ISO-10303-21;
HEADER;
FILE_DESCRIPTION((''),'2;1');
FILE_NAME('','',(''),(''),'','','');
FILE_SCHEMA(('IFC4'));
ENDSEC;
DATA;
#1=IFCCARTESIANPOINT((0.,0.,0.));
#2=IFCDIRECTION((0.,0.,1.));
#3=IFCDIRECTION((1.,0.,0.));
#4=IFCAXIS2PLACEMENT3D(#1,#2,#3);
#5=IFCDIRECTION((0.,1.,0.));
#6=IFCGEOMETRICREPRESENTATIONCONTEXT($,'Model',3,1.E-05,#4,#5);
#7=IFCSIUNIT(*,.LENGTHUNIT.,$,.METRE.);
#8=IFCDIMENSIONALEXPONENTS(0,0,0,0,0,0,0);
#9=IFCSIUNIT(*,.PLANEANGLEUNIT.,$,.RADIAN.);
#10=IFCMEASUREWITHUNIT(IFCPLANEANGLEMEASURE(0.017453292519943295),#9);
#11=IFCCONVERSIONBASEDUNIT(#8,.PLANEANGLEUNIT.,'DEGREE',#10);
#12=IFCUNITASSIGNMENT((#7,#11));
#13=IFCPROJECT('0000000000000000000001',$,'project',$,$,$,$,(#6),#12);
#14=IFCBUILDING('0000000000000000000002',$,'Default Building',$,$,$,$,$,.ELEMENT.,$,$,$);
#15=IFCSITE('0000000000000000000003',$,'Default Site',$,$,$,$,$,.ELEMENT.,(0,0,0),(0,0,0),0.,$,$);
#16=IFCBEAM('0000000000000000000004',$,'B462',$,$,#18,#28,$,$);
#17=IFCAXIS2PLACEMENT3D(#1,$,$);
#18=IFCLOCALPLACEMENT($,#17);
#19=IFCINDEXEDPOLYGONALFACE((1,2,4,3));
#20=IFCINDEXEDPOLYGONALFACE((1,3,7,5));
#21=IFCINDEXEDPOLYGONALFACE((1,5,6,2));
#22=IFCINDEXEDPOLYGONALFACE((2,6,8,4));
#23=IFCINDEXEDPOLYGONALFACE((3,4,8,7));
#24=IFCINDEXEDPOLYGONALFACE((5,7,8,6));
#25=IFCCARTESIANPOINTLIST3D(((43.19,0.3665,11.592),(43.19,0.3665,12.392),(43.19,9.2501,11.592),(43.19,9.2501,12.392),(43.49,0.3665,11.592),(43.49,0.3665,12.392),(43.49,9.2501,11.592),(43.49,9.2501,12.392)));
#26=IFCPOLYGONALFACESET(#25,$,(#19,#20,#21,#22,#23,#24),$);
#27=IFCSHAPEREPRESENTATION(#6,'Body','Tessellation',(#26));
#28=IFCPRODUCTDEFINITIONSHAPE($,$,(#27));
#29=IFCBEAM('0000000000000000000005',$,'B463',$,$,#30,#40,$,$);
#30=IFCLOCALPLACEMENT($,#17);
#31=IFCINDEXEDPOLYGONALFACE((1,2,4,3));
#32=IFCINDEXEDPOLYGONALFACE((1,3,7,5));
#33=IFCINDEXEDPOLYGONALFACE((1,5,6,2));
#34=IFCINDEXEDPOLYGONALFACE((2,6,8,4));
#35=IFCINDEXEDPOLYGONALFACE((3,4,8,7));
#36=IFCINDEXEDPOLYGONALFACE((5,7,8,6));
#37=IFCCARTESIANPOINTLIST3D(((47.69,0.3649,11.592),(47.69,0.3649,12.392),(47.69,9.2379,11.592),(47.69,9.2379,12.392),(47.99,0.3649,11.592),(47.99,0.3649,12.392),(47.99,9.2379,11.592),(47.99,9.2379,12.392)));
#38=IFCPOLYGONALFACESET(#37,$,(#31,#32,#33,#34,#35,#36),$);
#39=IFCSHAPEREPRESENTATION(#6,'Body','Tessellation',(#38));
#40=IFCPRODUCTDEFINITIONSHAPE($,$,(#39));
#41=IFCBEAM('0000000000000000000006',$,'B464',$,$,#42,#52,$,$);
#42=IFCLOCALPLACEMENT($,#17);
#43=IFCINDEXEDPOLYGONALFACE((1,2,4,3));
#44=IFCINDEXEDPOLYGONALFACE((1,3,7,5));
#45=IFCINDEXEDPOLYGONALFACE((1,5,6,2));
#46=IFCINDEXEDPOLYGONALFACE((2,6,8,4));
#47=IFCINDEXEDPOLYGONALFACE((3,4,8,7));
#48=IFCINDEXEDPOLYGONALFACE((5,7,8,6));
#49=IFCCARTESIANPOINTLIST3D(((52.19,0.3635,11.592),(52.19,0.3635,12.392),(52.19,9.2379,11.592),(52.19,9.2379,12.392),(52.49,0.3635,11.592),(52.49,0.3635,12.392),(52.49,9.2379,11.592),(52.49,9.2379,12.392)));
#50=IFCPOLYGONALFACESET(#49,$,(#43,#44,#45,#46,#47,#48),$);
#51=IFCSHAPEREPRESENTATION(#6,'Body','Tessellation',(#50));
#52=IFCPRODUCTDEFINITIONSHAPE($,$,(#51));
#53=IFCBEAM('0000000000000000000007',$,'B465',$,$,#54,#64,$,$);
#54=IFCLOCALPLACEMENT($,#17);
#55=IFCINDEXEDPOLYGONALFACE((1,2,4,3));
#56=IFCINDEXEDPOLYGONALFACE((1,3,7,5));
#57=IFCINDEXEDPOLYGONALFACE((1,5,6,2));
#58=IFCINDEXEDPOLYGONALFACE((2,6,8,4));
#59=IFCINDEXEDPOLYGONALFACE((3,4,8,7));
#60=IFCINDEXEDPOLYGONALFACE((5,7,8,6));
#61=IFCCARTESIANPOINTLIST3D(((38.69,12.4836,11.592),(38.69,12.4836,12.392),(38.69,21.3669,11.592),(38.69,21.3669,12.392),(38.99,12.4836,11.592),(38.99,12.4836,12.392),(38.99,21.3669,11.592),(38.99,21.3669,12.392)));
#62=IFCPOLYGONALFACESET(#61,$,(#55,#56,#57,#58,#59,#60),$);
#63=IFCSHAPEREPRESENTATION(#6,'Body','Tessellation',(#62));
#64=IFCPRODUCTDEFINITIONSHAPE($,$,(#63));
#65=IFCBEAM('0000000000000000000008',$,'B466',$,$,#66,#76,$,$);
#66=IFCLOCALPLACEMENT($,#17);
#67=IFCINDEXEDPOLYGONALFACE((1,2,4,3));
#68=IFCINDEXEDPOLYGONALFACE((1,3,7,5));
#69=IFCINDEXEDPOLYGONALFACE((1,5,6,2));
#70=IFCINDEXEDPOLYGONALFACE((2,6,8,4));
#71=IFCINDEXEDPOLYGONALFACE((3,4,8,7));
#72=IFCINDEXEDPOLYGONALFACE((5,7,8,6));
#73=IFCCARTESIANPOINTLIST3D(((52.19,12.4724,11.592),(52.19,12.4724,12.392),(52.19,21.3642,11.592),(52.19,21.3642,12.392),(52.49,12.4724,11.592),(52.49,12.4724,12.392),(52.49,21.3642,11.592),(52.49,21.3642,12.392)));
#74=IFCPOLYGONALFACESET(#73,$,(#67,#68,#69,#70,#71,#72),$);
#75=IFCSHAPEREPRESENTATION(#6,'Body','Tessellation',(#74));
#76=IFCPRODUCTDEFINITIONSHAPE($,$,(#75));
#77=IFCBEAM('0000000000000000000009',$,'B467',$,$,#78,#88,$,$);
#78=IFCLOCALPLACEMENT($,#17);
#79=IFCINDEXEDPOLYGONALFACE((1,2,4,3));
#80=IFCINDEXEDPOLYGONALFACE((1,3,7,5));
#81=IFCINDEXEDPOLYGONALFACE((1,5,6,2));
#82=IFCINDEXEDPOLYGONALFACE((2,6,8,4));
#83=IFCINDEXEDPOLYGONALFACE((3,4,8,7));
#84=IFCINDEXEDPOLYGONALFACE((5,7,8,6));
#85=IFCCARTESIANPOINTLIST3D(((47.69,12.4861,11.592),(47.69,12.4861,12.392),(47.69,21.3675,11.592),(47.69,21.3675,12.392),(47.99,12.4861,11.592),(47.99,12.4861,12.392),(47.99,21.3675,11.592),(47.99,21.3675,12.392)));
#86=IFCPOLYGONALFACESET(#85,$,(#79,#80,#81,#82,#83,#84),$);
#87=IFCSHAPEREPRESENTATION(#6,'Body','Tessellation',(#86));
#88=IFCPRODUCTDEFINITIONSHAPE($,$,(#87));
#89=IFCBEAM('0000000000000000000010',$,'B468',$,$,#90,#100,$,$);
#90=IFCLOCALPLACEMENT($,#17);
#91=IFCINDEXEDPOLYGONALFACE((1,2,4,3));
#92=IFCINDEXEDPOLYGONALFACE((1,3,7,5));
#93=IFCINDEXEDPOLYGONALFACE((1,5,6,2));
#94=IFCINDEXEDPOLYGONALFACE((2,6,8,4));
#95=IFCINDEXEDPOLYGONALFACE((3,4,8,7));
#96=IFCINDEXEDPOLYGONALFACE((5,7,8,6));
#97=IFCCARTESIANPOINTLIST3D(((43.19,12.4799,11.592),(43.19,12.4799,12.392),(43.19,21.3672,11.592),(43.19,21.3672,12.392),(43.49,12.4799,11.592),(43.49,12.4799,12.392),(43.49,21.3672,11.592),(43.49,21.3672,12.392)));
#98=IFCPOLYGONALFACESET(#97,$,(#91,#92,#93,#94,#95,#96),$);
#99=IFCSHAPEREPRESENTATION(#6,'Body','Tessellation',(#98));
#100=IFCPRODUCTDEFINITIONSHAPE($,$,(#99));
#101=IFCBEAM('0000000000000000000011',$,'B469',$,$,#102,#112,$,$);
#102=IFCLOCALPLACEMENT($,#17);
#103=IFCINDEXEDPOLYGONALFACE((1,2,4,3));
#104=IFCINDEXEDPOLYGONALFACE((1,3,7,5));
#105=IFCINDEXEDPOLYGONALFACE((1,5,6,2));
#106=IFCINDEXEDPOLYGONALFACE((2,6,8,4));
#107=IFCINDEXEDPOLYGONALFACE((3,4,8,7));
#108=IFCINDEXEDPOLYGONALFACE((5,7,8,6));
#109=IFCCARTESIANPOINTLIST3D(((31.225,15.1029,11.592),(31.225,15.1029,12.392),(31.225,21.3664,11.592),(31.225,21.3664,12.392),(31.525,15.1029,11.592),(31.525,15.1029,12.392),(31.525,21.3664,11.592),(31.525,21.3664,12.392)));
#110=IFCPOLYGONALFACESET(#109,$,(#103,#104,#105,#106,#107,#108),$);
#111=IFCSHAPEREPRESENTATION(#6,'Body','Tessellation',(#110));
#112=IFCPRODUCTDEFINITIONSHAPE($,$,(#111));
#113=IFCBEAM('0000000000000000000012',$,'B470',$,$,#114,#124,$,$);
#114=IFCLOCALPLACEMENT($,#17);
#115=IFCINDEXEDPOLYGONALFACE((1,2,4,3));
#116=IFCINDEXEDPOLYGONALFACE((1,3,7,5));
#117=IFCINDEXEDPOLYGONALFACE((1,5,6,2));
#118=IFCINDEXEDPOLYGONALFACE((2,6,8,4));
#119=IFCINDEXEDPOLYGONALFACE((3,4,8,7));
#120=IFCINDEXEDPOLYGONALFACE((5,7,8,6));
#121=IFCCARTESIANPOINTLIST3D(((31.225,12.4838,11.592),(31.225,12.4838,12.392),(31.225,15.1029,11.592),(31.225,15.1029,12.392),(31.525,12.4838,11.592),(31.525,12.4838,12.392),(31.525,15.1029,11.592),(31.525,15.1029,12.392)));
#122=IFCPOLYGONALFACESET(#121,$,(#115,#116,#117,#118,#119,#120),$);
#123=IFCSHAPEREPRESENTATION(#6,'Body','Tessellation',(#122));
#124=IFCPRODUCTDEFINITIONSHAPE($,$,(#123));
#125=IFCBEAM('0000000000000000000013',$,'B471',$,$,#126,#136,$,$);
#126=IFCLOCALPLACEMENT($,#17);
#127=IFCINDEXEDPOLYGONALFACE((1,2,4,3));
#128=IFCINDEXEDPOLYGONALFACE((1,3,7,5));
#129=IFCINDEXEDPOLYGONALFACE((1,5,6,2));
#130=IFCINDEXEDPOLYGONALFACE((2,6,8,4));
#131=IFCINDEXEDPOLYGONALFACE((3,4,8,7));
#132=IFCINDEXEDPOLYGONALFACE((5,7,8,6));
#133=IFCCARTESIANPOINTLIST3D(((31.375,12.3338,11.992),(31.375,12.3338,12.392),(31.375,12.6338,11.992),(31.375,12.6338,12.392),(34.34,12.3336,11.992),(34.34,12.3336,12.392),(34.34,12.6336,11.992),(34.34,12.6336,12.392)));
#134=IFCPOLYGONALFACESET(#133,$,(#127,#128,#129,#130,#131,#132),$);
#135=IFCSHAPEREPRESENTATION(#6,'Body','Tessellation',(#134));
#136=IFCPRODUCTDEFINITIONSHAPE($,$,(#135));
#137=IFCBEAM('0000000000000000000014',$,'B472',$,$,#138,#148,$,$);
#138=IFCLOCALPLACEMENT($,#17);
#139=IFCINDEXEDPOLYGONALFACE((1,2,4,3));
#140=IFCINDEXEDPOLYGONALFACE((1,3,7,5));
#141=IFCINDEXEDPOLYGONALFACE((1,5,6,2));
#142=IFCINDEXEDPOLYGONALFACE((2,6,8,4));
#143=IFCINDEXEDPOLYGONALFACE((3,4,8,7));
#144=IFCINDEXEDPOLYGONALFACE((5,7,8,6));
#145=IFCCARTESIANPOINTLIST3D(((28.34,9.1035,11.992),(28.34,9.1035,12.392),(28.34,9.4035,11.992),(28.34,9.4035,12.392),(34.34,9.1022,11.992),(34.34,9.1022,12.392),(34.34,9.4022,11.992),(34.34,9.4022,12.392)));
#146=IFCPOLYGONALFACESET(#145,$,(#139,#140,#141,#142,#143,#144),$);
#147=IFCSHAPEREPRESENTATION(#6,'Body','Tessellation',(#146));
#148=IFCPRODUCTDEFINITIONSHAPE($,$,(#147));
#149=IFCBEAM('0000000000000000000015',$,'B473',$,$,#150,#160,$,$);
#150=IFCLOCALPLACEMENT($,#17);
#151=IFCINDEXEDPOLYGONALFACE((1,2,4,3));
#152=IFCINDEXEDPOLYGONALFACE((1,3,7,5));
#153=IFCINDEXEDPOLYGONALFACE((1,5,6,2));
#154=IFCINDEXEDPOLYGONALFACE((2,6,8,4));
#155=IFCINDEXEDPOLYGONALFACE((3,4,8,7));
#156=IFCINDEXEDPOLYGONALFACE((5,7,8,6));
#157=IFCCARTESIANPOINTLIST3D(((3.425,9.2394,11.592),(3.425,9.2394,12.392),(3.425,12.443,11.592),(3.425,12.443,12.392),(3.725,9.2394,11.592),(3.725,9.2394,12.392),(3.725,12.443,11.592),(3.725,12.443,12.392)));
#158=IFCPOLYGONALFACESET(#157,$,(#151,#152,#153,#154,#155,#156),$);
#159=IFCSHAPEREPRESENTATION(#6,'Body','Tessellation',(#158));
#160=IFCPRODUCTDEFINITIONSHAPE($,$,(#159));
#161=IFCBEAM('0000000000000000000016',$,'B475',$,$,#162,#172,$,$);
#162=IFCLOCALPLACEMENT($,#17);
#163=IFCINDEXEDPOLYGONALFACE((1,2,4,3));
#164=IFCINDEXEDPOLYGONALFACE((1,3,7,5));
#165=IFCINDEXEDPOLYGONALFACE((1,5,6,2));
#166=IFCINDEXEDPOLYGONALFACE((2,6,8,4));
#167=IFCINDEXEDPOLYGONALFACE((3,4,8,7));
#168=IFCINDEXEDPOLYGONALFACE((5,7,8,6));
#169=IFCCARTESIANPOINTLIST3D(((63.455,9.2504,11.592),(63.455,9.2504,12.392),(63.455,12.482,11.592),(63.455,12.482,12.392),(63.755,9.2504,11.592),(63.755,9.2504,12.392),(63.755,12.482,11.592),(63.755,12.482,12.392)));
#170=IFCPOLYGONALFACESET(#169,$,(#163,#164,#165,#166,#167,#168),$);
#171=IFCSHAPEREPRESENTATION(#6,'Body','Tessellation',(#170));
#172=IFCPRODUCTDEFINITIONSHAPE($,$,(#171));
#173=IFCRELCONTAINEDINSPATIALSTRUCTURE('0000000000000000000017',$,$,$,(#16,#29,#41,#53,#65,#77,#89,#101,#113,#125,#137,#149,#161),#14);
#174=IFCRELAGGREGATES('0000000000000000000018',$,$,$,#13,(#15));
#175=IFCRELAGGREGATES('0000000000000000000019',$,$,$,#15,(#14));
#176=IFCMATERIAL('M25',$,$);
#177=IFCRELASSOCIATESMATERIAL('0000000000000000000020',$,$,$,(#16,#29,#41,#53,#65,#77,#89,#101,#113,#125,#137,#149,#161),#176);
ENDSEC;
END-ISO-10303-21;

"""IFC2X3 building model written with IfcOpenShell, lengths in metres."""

from ifc_helpers import new_model, entity, si_unit, converted_unit, direction, frame, frame_2d, origin_with_axes, place, context, project, spatial, rectangle, extrude, material, element, save


model = new_model("IFC2X3")

# Units and contexts
model_context = context("Model", 3, precision=1e-05, world=origin_with_axes(), true_north=direction((0.0, 1.0, 0.0)))
ifc_project = project(units=[si_unit("LENGTHUNIT", "METRE"), converted_unit("PLANEANGLEUNIT", "DEGREE", entity("IfcPlaneAngleMeasure", 0.017453292519943295), si_unit("PLANEANGLEUNIT", "RADIAN"), dimensions=[0, 0, 0, 0, 0, 0, 0])], contexts=[model_context])

# Site, building
site = spatial("IfcSite", under=ifc_project, Name="Default Site", CompositionType="ELEMENT", RefLatitude=(0, 0, 0), RefLongitude=(0, 0, 0), RefElevation=0.0)
building = spatial("IfcBuilding", under=site, Name="Default Building", CompositionType="ELEMENT")

# Shared definitions
ifc_material = material(Name="M25")
placement = place(None, origin_with_axes())

# Beams
element("IfcBeam", 1, at=placement, inside=building, material=ifc_material, Name="B462", context=model_context, shape_type="SweptSolid", body=[
    extrude(rectangle(XDim=0.3, YDim=0.8, at=frame_2d((0.0, 0.0), x_axis=(0.0, 1.0, 0.0))), frame((43.34, 0.3665, 11.992), z_axis=(0.0, 1.0, 0.0), x_axis=(0.0, 0.0, -1.0)), (0.0, 0.0, 1.0), 8.8836),
])
element("IfcBeam", 2, at=placement, inside=building, material=ifc_material, Name="B463", context=model_context, shape_type="SweptSolid", body=[
    extrude(rectangle(XDim=0.3, YDim=0.8, at=frame_2d((0.0, 0.0), x_axis=(0.0, 1.0, 0.0))), frame((47.84, 0.3649, 11.992), z_axis=(0.0, 1.0, 0.0), x_axis=(0.0, 0.0, -1.0)), (0.0, 0.0, 1.0), 8.873),
])
element("IfcBeam", 3, at=placement, inside=building, material=ifc_material, Name="B464", context=model_context, shape_type="SweptSolid", body=[
    extrude(rectangle(XDim=0.3, YDim=0.8, at=frame_2d((0.0, 0.0), x_axis=(0.0, 1.0, 0.0))), frame((52.34, 0.3635, 11.992), z_axis=(0.0, 1.0, 0.0), x_axis=(0.0, 0.0, -1.0)), (0.0, 0.0, 1.0), 8.8744),
])
element("IfcBeam", 4, at=placement, inside=building, material=ifc_material, Name="B465", context=model_context, shape_type="SweptSolid", body=[
    extrude(rectangle(XDim=0.3, YDim=0.8, at=frame_2d((0.0, 0.0), x_axis=(0.0, 1.0, 0.0))), frame((38.84, 21.3669, 11.992), z_axis=(0.0, -1.0, 0.0), x_axis=(0.0, 0.0, -1.0)), (0.0, 0.0, 1.0), 8.8833),
])
element("IfcBeam", 5, at=placement, inside=building, material=ifc_material, Name="B466", context=model_context, shape_type="SweptSolid", body=[
    extrude(rectangle(XDim=0.3, YDim=0.8, at=frame_2d((0.0, 0.0), x_axis=(0.0, 1.0, 0.0))), frame((52.34, 12.4724, 11.992), z_axis=(0.0, 1.0, 0.0), x_axis=(0.0, 0.0, -1.0)), (0.0, 0.0, 1.0), 8.8918),
])
element("IfcBeam", 6, at=placement, inside=building, material=ifc_material, Name="B467", context=model_context, shape_type="SweptSolid", body=[
    extrude(rectangle(XDim=0.3, YDim=0.8, at=frame_2d((0.0, 0.0), x_axis=(0.0, 1.0, 0.0))), frame((47.84, 12.4861, 11.992), z_axis=(0.0, 1.0, 0.0), x_axis=(0.0, 0.0, -1.0)), (0.0, 0.0, 1.0), 8.8814),
])
element("IfcBeam", 7, at=placement, inside=building, material=ifc_material, Name="B468", context=model_context, shape_type="SweptSolid", body=[
    extrude(rectangle(XDim=0.3, YDim=0.8, at=frame_2d((0.0, 0.0), x_axis=(0.0, 1.0, 0.0))), frame((43.34, 21.3672, 11.992), z_axis=(0.0, -1.0, 0.0), x_axis=(0.0, 0.0, -1.0)), (0.0, 0.0, 1.0), 8.8873),
])
element("IfcBeam", 8, at=placement, inside=building, material=ifc_material, Name="B469", context=model_context, shape_type="SweptSolid", body=[
    extrude(rectangle(XDim=0.3, YDim=0.8, at=frame_2d((0.0, 0.0), x_axis=(0.0, 1.0, 0.0))), frame((31.375, 21.3664, 11.992), z_axis=(0.0, -1.0, 0.0), x_axis=(0.0, 0.0, -1.0)), (0.0, 0.0, 1.0), 6.2635),
])
element("IfcBeam", 9, at=placement, inside=building, material=ifc_material, Name="B470", context=model_context, shape_type="SweptSolid", body=[
    extrude(rectangle(XDim=0.3, YDim=0.8, at=frame_2d((0.0, 0.0), x_axis=(0.0, 1.0, 0.0))), frame((31.375, 15.1029, 11.992), z_axis=(0.0, -1.0, 0.0), x_axis=(0.0, 0.0, -1.0)), (0.0, 0.0, 1.0), 2.6191),
])
element("IfcBeam", 10, at=placement, inside=building, material=ifc_material, Name="B471", context=model_context, shape_type="SweptSolid", body=[
    extrude(rectangle(XDim=0.3, YDim=0.4, at=frame_2d((0.0, 0.0), x_axis=(0.0, 1.0, 0.0))), frame((31.375, 12.4838, 12.192), z_axis=(1.0, -0.000067, 0.0), x_axis=(0.0, 0.0, -1.0)), (0.0, 0.0, 1.0), 2.965),
])
element("IfcBeam", 11, at=placement, inside=building, material=ifc_material, Name="B472", context=model_context, shape_type="SweptSolid", body=[
    extrude(rectangle(XDim=0.3, YDim=0.4, at=frame_2d((0.0, 0.0), x_axis=(0.0, 1.0, 0.0))), frame((28.34, 9.2535, 12.192), z_axis=(1.0, -0.000213, 0.0), x_axis=(0.0, 0.0, -1.0)), (0.0, 0.0, 1.0), 6.0),
])
element("IfcBeam", 12, at=placement, inside=building, material=ifc_material, Name="B473", context=model_context, shape_type="SweptSolid", body=[
    extrude(rectangle(XDim=0.3, YDim=0.8, at=frame_2d((0.0, 0.0), x_axis=(0.0, 1.0, 0.0))), frame((3.575, 12.443, 11.992), z_axis=(0.0, -1.0, 0.0), x_axis=(0.0, 0.0, -1.0)), (0.0, 0.0, 1.0), 3.2036),
])
element("IfcBeam", 13, at=placement, inside=building, material=ifc_material, Name="B475", context=model_context, shape_type="SweptSolid", body=[
    extrude(rectangle(XDim=0.3, YDim=0.8, at=frame_2d((0.0, 0.0), x_axis=(0.0, 1.0, 0.0))), frame((63.605, 12.482, 11.992), z_axis=(0.0, -1.0, 0.0), x_axis=(0.0, 0.0, -1.0)), (0.0, 0.0, 1.0), 3.2316),
])

save(model, "model.ifc")
